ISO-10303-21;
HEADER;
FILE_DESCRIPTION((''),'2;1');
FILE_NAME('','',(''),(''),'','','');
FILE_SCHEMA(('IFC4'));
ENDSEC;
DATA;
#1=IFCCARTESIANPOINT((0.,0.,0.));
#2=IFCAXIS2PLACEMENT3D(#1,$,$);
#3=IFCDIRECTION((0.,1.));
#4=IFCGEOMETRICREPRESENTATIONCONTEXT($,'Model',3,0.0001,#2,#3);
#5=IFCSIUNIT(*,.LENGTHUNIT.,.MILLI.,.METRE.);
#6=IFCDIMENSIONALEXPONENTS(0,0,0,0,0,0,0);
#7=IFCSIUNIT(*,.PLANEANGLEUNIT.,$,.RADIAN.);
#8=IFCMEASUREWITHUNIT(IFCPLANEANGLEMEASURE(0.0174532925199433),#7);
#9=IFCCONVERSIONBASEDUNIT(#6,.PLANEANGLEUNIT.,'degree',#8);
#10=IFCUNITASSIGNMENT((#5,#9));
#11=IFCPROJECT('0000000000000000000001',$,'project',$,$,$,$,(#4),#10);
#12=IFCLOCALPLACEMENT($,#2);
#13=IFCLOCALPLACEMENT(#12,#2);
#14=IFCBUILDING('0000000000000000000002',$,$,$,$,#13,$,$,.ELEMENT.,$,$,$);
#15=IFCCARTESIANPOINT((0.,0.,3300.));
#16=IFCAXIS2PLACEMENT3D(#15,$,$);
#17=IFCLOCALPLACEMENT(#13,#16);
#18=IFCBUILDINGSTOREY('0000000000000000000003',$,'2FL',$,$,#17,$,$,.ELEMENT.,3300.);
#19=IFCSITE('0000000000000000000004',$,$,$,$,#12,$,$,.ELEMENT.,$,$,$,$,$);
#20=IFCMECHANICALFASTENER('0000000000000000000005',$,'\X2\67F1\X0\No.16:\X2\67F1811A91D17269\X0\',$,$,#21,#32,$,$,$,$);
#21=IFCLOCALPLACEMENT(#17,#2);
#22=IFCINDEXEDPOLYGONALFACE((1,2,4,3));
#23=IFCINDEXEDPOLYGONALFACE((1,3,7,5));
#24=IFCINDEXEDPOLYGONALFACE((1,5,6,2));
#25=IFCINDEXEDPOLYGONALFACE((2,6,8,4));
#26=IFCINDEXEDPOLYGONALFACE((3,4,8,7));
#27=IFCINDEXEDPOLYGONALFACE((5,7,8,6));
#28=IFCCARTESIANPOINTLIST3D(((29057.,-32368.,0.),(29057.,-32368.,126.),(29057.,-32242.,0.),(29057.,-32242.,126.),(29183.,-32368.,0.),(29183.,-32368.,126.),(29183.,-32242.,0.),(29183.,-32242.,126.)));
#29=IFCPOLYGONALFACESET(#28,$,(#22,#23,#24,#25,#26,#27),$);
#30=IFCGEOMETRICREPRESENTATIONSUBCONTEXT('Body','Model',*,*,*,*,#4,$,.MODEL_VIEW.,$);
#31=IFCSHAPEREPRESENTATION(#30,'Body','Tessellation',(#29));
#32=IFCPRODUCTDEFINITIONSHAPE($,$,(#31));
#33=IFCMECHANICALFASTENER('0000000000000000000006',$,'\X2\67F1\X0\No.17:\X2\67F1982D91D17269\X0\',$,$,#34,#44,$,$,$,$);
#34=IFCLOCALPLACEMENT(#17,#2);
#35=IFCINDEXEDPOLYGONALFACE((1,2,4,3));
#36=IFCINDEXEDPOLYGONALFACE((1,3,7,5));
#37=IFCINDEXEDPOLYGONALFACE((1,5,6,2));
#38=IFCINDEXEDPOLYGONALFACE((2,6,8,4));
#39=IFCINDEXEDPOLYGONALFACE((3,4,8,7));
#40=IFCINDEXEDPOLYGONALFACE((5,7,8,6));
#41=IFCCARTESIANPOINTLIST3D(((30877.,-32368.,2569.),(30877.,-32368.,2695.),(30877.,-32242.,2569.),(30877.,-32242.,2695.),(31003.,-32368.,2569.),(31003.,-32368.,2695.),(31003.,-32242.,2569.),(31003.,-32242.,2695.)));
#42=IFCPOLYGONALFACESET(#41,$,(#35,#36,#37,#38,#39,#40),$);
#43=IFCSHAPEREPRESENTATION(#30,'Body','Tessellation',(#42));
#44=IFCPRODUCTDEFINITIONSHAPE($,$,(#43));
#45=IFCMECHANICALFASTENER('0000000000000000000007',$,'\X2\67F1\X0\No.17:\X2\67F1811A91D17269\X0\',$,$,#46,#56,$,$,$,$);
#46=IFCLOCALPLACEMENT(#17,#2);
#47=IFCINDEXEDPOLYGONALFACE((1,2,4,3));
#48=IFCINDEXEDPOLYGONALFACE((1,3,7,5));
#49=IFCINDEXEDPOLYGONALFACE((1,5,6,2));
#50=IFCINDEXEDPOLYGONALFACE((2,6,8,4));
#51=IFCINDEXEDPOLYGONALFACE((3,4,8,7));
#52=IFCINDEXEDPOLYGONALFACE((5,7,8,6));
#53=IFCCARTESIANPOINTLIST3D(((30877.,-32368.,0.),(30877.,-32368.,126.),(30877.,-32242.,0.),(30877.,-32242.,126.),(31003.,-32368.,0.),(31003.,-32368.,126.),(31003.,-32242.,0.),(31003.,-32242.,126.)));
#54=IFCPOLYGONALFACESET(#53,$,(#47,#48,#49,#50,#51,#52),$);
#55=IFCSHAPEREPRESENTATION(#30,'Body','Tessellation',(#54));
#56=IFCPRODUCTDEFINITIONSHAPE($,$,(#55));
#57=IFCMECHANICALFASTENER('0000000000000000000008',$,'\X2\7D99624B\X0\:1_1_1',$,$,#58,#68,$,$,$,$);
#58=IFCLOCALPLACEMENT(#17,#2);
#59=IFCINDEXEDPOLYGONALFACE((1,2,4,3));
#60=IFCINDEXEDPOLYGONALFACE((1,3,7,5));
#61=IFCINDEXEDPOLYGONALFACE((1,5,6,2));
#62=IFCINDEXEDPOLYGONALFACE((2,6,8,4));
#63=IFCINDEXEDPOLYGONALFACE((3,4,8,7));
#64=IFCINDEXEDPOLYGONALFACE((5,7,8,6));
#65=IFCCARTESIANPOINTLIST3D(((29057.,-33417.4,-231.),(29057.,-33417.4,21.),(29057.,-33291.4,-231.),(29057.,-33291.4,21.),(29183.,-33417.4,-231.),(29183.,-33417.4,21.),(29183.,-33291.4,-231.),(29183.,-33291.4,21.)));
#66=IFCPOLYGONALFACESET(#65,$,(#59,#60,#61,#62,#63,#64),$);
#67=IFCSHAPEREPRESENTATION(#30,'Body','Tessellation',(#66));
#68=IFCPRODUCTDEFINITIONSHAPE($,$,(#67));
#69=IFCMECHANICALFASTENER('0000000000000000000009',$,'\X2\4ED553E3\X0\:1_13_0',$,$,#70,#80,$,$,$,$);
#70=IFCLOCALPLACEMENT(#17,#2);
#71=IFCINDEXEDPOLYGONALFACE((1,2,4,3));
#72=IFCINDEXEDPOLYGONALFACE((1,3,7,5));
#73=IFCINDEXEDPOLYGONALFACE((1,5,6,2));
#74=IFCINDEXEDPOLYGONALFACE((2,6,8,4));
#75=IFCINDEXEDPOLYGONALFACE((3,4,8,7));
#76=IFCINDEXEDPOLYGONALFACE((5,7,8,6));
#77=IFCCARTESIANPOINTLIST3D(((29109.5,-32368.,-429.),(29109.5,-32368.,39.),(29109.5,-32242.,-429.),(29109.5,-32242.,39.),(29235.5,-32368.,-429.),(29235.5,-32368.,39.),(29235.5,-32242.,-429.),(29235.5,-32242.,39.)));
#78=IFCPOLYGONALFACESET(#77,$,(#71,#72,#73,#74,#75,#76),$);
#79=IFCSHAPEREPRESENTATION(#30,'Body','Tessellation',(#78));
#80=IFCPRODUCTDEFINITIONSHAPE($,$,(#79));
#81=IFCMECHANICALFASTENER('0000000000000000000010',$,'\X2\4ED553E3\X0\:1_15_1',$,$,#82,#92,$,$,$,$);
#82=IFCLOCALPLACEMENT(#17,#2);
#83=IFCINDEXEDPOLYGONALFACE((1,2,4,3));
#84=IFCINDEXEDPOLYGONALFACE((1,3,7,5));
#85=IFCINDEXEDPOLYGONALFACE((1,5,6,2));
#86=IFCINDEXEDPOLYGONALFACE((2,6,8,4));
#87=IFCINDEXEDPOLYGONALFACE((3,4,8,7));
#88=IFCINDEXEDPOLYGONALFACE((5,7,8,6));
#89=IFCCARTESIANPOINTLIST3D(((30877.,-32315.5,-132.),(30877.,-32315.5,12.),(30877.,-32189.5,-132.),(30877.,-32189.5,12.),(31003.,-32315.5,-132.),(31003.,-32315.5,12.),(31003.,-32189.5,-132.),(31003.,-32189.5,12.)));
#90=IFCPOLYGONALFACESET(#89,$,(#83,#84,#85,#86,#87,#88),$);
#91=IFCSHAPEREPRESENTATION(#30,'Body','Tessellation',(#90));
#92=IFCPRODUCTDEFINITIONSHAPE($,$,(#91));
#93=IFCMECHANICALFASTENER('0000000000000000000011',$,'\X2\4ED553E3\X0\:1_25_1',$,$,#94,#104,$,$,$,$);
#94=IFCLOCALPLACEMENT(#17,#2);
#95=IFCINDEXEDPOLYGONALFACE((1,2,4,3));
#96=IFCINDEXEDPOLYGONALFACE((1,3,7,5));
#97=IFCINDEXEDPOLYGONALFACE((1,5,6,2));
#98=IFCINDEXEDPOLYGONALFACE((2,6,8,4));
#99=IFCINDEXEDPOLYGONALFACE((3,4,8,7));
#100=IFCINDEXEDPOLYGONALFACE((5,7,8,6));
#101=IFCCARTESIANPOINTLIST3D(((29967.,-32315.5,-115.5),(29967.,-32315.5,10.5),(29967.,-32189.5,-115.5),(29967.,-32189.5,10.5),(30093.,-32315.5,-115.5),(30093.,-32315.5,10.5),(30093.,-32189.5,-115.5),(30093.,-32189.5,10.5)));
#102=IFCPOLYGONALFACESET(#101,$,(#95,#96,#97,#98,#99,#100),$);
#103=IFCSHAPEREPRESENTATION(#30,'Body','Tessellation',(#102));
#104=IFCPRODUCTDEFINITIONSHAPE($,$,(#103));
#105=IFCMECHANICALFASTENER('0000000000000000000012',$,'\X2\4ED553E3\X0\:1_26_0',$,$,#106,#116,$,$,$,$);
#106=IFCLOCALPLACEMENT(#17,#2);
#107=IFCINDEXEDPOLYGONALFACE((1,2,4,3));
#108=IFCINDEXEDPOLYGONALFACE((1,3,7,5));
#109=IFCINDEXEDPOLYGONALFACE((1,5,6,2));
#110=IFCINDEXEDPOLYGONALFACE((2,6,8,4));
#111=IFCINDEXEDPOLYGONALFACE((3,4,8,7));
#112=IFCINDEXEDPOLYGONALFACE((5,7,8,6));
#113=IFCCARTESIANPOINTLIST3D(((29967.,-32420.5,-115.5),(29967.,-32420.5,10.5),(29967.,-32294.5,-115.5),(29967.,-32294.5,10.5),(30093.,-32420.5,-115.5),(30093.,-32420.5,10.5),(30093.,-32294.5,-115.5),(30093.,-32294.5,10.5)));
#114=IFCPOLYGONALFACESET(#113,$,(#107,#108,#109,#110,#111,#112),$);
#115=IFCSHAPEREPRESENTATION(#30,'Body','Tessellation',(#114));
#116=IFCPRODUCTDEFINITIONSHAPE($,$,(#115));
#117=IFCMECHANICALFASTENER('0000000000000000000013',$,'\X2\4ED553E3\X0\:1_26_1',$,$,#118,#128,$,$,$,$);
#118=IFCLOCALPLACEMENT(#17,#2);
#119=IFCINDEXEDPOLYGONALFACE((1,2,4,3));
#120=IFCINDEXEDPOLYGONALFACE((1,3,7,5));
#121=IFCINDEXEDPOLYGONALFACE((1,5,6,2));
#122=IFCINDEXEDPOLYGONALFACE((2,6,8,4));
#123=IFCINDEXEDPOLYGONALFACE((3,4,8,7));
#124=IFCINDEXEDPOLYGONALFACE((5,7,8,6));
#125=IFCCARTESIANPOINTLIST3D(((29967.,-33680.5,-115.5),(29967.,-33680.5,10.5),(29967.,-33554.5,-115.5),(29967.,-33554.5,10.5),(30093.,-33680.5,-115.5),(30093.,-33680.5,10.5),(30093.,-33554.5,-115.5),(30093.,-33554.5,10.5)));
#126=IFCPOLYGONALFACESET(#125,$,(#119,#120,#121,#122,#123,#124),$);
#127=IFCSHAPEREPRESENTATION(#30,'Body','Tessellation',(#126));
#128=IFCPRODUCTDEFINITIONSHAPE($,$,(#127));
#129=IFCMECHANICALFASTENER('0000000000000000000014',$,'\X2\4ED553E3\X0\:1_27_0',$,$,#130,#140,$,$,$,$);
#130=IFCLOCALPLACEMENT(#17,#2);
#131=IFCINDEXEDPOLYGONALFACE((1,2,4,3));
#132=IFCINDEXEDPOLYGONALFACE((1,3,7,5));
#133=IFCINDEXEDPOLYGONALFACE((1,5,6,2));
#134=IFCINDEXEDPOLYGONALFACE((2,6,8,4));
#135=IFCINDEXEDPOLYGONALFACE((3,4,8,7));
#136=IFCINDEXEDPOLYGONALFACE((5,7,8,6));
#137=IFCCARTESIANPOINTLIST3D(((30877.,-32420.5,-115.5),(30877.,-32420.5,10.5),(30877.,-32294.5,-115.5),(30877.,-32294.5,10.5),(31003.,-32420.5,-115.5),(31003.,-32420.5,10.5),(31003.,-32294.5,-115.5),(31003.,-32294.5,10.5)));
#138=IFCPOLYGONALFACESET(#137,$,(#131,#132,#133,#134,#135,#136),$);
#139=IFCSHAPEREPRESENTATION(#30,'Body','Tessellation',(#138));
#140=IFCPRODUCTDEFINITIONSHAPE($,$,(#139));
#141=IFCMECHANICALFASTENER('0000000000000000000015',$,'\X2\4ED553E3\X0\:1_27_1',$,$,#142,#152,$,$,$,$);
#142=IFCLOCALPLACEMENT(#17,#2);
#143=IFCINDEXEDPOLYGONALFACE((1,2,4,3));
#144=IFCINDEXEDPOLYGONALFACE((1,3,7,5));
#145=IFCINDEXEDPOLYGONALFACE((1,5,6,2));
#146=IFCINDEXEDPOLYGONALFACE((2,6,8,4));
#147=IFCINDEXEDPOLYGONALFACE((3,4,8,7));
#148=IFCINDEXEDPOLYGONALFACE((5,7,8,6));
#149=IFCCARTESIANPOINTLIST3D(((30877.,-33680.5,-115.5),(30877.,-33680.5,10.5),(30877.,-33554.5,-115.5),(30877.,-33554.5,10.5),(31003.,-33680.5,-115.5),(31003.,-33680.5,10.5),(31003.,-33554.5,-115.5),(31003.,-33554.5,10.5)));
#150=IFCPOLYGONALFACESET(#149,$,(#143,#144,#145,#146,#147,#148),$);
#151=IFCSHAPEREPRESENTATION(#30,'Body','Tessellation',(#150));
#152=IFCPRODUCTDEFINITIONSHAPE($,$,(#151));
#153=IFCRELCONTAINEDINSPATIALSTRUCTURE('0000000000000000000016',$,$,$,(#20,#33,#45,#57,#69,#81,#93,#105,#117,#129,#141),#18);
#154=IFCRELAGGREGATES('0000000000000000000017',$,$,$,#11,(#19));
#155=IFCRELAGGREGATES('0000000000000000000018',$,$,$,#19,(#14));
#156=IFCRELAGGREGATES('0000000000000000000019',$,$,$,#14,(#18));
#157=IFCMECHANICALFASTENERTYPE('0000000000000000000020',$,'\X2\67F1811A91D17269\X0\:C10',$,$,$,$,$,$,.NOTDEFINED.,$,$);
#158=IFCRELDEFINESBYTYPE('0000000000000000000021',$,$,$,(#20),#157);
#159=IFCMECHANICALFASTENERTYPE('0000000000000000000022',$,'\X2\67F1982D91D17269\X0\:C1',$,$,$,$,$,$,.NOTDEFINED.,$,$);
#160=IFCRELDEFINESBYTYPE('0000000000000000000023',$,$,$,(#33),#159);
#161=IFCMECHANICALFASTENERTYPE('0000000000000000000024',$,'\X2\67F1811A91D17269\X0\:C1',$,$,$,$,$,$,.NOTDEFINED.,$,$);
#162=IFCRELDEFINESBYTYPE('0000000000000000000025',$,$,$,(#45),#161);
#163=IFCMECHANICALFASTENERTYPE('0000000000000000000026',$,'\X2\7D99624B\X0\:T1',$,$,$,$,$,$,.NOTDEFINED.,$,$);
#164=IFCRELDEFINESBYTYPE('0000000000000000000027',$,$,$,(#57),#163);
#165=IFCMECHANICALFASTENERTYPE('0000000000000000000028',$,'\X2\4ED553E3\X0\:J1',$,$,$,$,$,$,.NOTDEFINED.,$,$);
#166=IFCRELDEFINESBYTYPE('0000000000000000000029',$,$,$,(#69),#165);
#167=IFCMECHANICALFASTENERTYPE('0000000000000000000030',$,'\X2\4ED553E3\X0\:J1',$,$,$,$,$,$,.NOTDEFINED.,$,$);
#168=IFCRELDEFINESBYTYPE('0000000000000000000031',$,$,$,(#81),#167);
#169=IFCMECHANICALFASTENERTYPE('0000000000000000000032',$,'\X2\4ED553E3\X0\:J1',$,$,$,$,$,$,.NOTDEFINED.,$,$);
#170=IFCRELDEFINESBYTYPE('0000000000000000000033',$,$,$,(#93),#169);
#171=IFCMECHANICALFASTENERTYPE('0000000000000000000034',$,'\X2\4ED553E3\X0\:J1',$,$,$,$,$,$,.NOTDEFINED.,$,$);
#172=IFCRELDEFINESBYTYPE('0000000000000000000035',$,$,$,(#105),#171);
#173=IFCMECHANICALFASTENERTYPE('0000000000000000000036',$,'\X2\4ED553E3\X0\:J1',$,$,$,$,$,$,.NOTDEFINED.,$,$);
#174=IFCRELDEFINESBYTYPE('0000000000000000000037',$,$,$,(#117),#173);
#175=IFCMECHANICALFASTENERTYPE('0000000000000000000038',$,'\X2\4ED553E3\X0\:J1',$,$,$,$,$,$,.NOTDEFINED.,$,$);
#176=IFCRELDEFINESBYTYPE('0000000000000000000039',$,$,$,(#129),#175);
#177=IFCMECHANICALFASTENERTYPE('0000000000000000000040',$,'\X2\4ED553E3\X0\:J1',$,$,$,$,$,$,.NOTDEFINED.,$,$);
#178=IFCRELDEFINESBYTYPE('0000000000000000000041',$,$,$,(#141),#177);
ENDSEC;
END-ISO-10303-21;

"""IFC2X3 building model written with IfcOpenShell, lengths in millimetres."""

from ifc_helpers import new_model, entity, si_unit, converted_unit, direction, frame, origin, origin_with_axes, origin_2d, place, context, subcontext, project, spatial, rectangle, extrude, type_object, element, save


model = new_model("IFC2X3")

# Units and contexts
model_context = context("Model", 3, precision=0.0001, world=origin(), true_north=direction((0.0, 1.0)))
body_context = subcontext(model_context, "Body", "Model", "MODEL_VIEW")
ifc_project = project(units=[si_unit("LENGTHUNIT", "METRE", prefix="MILLI"), converted_unit("PLANEANGLEUNIT", "degree", entity("IfcPlaneAngleMeasure", 0.0174532925199433), si_unit("PLANEANGLEUNIT", "RADIAN"), dimensions=[0, 0, 0, 0, 0, 0, 0])], contexts=[model_context])

# Site, building, storey
site_placement = place(None, origin())
site = spatial("IfcSite", under=ifc_project, at=site_placement, CompositionType="ELEMENT")
building_placement = place(site_placement, origin())
building = spatial("IfcBuilding", under=site, at=building_placement, CompositionType="ELEMENT")
storey_placement = place(building_placement, frame((0.0, 0.0, 3300.0)))
storey = spatial("IfcBuildingStorey", under=building, at=storey_placement, Name="2FL", CompositionType="ELEMENT", Elevation=3300.0)

# Mechanical fasteners
mechanical_fastener_type_1 = type_object("IfcMechanicalFastenerType", Name="柱脚金物:C10")
mechanical_fastener_1_placement = place(storey_placement, frame((29120.0, -32305.0, 0.0)))
element("IfcMechanicalFastener", 1, at=mechanical_fastener_1_placement, inside=storey, type_object=mechanical_fastener_type_1, Name="柱No.16:柱脚金物", context=body_context, shape_type="SweptSolid", body=[
    extrude(rectangle(XDim=126.0, YDim=126.0, at=origin_2d()), origin_with_axes(), (0.0, 0.0, 1.0), 126.0),
])
mechanical_fastener_type_2 = type_object("IfcMechanicalFastenerType", Name="柱頭金物:C1")
mechanical_fastener_2_placement = place(storey_placement, frame((30940.0, -32305.0, 2569.0)))
element("IfcMechanicalFastener", 2, at=mechanical_fastener_2_placement, inside=storey, type_object=mechanical_fastener_type_2, Name="柱No.17:柱頭金物", context=body_context, shape_type="SweptSolid", body=[
    extrude(rectangle(XDim=126.0, YDim=126.0, at=origin_2d()), origin_with_axes(), (0.0, 0.0, 1.0), 126.0),
])
mechanical_fastener_type_3 = type_object("IfcMechanicalFastenerType", Name="柱脚金物:C1")
mechanical_fastener_3_placement = place(storey_placement, frame((30940.0, -32305.0, 0.0)))
element("IfcMechanicalFastener", 3, at=mechanical_fastener_3_placement, inside=storey, type_object=mechanical_fastener_type_3, Name="柱No.17:柱脚金物", context=body_context, shape_type="SweptSolid", body=[
    extrude(rectangle(XDim=126.0, YDim=126.0, at=origin_2d()), origin_with_axes(), (0.0, 0.0, 1.0), 126.0),
])
mechanical_fastener_type_4 = type_object("IfcMechanicalFastenerType", Name="継手:T1")
mechanical_fastener_4_placement = place(storey_placement, frame((29120.0, -33354.4, -231.0)))
element("IfcMechanicalFastener", 4, at=mechanical_fastener_4_placement, inside=storey, type_object=mechanical_fastener_type_4, Name="継手:1_1_1", context=body_context, shape_type="SweptSolid", body=[
    extrude(rectangle(XDim=126.0, YDim=126.0, at=origin_2d()), origin_with_axes(), (0.0, 0.0, 1.0), 252.0),
])
mechanical_fastener_type_5 = type_object("IfcMechanicalFastenerType", Name="仕口:J1")
mechanical_fastener_5_placement = place(storey_placement, frame((29172.5, -32305.0, -429.0)))
element("IfcMechanicalFastener", 5, at=mechanical_fastener_5_placement, inside=storey, type_object=mechanical_fastener_type_5, Name="仕口:1_13_0", context=body_context, shape_type="SweptSolid", body=[
    extrude(rectangle(XDim=126.0, YDim=126.0, at=origin_2d()), origin_with_axes(), (0.0, 0.0, 1.0), 468.0),
])
mechanical_fastener_type_6 = type_object("IfcMechanicalFastenerType", Name="仕口:J1")
mechanical_fastener_6_placement = place(storey_placement, frame((30940.0, -32252.5, -132.0)))
element("IfcMechanicalFastener", 6, at=mechanical_fastener_6_placement, inside=storey, type_object=mechanical_fastener_type_6, Name="仕口:1_15_1", context=body_context, shape_type="SweptSolid", body=[
    extrude(rectangle(XDim=126.0, YDim=126.0, at=origin_2d()), origin_with_axes(), (0.0, 0.0, 1.0), 144.0),
])
mechanical_fastener_type_7 = type_object("IfcMechanicalFastenerType", Name="仕口:J1")
mechanical_fastener_7_placement = place(storey_placement, frame((30030.0, -32252.5, -115.5)))
element("IfcMechanicalFastener", 7, at=mechanical_fastener_7_placement, inside=storey, type_object=mechanical_fastener_type_7, Name="仕口:1_25_1", context=body_context, shape_type="SweptSolid", body=[
    extrude(rectangle(XDim=126.0, YDim=126.0, at=origin_2d()), origin_with_axes(), (0.0, 0.0, 1.0), 126.0),
])
mechanical_fastener_type_8 = type_object("IfcMechanicalFastenerType", Name="仕口:J1")
mechanical_fastener_8_placement = place(storey_placement, frame((30030.0, -32357.5, -115.5)))
element("IfcMechanicalFastener", 8, at=mechanical_fastener_8_placement, inside=storey, type_object=mechanical_fastener_type_8, Name="仕口:1_26_0", context=body_context, shape_type="SweptSolid", body=[
    extrude(rectangle(XDim=126.0, YDim=126.0, at=origin_2d()), origin_with_axes(), (0.0, 0.0, 1.0), 126.0),
])
mechanical_fastener_type_9 = type_object("IfcMechanicalFastenerType", Name="仕口:J1")
mechanical_fastener_9_placement = place(storey_placement, frame((30030.0, -33617.5, -115.5)))
element("IfcMechanicalFastener", 9, at=mechanical_fastener_9_placement, inside=storey, type_object=mechanical_fastener_type_9, Name="仕口:1_26_1", context=body_context, shape_type="SweptSolid", body=[
    extrude(rectangle(XDim=126.0, YDim=126.0, at=origin_2d()), origin_with_axes(), (0.0, 0.0, 1.0), 126.0),
])
mechanical_fastener_type_10 = type_object("IfcMechanicalFastenerType", Name="仕口:J1")
mechanical_fastener_10_placement = place(storey_placement, frame((30940.0, -32357.5, -115.5)))
element("IfcMechanicalFastener", 10, at=mechanical_fastener_10_placement, inside=storey, type_object=mechanical_fastener_type_10, Name="仕口:1_27_0", context=body_context, shape_type="SweptSolid", body=[
    extrude(rectangle(XDim=126.0, YDim=126.0, at=origin_2d()), origin_with_axes(), (0.0, 0.0, 1.0), 126.0),
])
mechanical_fastener_type_11 = type_object("IfcMechanicalFastenerType", Name="仕口:J1")
mechanical_fastener_11_placement = place(storey_placement, frame((30940.0, -33617.5, -115.5)))
element("IfcMechanicalFastener", 11, at=mechanical_fastener_11_placement, inside=storey, type_object=mechanical_fastener_type_11, Name="仕口:1_27_1", context=body_context, shape_type="SweptSolid", body=[
    extrude(rectangle(XDim=126.0, YDim=126.0, at=origin_2d()), origin_with_axes(), (0.0, 0.0, 1.0), 126.0),
])

save(model, "model.ifc")
